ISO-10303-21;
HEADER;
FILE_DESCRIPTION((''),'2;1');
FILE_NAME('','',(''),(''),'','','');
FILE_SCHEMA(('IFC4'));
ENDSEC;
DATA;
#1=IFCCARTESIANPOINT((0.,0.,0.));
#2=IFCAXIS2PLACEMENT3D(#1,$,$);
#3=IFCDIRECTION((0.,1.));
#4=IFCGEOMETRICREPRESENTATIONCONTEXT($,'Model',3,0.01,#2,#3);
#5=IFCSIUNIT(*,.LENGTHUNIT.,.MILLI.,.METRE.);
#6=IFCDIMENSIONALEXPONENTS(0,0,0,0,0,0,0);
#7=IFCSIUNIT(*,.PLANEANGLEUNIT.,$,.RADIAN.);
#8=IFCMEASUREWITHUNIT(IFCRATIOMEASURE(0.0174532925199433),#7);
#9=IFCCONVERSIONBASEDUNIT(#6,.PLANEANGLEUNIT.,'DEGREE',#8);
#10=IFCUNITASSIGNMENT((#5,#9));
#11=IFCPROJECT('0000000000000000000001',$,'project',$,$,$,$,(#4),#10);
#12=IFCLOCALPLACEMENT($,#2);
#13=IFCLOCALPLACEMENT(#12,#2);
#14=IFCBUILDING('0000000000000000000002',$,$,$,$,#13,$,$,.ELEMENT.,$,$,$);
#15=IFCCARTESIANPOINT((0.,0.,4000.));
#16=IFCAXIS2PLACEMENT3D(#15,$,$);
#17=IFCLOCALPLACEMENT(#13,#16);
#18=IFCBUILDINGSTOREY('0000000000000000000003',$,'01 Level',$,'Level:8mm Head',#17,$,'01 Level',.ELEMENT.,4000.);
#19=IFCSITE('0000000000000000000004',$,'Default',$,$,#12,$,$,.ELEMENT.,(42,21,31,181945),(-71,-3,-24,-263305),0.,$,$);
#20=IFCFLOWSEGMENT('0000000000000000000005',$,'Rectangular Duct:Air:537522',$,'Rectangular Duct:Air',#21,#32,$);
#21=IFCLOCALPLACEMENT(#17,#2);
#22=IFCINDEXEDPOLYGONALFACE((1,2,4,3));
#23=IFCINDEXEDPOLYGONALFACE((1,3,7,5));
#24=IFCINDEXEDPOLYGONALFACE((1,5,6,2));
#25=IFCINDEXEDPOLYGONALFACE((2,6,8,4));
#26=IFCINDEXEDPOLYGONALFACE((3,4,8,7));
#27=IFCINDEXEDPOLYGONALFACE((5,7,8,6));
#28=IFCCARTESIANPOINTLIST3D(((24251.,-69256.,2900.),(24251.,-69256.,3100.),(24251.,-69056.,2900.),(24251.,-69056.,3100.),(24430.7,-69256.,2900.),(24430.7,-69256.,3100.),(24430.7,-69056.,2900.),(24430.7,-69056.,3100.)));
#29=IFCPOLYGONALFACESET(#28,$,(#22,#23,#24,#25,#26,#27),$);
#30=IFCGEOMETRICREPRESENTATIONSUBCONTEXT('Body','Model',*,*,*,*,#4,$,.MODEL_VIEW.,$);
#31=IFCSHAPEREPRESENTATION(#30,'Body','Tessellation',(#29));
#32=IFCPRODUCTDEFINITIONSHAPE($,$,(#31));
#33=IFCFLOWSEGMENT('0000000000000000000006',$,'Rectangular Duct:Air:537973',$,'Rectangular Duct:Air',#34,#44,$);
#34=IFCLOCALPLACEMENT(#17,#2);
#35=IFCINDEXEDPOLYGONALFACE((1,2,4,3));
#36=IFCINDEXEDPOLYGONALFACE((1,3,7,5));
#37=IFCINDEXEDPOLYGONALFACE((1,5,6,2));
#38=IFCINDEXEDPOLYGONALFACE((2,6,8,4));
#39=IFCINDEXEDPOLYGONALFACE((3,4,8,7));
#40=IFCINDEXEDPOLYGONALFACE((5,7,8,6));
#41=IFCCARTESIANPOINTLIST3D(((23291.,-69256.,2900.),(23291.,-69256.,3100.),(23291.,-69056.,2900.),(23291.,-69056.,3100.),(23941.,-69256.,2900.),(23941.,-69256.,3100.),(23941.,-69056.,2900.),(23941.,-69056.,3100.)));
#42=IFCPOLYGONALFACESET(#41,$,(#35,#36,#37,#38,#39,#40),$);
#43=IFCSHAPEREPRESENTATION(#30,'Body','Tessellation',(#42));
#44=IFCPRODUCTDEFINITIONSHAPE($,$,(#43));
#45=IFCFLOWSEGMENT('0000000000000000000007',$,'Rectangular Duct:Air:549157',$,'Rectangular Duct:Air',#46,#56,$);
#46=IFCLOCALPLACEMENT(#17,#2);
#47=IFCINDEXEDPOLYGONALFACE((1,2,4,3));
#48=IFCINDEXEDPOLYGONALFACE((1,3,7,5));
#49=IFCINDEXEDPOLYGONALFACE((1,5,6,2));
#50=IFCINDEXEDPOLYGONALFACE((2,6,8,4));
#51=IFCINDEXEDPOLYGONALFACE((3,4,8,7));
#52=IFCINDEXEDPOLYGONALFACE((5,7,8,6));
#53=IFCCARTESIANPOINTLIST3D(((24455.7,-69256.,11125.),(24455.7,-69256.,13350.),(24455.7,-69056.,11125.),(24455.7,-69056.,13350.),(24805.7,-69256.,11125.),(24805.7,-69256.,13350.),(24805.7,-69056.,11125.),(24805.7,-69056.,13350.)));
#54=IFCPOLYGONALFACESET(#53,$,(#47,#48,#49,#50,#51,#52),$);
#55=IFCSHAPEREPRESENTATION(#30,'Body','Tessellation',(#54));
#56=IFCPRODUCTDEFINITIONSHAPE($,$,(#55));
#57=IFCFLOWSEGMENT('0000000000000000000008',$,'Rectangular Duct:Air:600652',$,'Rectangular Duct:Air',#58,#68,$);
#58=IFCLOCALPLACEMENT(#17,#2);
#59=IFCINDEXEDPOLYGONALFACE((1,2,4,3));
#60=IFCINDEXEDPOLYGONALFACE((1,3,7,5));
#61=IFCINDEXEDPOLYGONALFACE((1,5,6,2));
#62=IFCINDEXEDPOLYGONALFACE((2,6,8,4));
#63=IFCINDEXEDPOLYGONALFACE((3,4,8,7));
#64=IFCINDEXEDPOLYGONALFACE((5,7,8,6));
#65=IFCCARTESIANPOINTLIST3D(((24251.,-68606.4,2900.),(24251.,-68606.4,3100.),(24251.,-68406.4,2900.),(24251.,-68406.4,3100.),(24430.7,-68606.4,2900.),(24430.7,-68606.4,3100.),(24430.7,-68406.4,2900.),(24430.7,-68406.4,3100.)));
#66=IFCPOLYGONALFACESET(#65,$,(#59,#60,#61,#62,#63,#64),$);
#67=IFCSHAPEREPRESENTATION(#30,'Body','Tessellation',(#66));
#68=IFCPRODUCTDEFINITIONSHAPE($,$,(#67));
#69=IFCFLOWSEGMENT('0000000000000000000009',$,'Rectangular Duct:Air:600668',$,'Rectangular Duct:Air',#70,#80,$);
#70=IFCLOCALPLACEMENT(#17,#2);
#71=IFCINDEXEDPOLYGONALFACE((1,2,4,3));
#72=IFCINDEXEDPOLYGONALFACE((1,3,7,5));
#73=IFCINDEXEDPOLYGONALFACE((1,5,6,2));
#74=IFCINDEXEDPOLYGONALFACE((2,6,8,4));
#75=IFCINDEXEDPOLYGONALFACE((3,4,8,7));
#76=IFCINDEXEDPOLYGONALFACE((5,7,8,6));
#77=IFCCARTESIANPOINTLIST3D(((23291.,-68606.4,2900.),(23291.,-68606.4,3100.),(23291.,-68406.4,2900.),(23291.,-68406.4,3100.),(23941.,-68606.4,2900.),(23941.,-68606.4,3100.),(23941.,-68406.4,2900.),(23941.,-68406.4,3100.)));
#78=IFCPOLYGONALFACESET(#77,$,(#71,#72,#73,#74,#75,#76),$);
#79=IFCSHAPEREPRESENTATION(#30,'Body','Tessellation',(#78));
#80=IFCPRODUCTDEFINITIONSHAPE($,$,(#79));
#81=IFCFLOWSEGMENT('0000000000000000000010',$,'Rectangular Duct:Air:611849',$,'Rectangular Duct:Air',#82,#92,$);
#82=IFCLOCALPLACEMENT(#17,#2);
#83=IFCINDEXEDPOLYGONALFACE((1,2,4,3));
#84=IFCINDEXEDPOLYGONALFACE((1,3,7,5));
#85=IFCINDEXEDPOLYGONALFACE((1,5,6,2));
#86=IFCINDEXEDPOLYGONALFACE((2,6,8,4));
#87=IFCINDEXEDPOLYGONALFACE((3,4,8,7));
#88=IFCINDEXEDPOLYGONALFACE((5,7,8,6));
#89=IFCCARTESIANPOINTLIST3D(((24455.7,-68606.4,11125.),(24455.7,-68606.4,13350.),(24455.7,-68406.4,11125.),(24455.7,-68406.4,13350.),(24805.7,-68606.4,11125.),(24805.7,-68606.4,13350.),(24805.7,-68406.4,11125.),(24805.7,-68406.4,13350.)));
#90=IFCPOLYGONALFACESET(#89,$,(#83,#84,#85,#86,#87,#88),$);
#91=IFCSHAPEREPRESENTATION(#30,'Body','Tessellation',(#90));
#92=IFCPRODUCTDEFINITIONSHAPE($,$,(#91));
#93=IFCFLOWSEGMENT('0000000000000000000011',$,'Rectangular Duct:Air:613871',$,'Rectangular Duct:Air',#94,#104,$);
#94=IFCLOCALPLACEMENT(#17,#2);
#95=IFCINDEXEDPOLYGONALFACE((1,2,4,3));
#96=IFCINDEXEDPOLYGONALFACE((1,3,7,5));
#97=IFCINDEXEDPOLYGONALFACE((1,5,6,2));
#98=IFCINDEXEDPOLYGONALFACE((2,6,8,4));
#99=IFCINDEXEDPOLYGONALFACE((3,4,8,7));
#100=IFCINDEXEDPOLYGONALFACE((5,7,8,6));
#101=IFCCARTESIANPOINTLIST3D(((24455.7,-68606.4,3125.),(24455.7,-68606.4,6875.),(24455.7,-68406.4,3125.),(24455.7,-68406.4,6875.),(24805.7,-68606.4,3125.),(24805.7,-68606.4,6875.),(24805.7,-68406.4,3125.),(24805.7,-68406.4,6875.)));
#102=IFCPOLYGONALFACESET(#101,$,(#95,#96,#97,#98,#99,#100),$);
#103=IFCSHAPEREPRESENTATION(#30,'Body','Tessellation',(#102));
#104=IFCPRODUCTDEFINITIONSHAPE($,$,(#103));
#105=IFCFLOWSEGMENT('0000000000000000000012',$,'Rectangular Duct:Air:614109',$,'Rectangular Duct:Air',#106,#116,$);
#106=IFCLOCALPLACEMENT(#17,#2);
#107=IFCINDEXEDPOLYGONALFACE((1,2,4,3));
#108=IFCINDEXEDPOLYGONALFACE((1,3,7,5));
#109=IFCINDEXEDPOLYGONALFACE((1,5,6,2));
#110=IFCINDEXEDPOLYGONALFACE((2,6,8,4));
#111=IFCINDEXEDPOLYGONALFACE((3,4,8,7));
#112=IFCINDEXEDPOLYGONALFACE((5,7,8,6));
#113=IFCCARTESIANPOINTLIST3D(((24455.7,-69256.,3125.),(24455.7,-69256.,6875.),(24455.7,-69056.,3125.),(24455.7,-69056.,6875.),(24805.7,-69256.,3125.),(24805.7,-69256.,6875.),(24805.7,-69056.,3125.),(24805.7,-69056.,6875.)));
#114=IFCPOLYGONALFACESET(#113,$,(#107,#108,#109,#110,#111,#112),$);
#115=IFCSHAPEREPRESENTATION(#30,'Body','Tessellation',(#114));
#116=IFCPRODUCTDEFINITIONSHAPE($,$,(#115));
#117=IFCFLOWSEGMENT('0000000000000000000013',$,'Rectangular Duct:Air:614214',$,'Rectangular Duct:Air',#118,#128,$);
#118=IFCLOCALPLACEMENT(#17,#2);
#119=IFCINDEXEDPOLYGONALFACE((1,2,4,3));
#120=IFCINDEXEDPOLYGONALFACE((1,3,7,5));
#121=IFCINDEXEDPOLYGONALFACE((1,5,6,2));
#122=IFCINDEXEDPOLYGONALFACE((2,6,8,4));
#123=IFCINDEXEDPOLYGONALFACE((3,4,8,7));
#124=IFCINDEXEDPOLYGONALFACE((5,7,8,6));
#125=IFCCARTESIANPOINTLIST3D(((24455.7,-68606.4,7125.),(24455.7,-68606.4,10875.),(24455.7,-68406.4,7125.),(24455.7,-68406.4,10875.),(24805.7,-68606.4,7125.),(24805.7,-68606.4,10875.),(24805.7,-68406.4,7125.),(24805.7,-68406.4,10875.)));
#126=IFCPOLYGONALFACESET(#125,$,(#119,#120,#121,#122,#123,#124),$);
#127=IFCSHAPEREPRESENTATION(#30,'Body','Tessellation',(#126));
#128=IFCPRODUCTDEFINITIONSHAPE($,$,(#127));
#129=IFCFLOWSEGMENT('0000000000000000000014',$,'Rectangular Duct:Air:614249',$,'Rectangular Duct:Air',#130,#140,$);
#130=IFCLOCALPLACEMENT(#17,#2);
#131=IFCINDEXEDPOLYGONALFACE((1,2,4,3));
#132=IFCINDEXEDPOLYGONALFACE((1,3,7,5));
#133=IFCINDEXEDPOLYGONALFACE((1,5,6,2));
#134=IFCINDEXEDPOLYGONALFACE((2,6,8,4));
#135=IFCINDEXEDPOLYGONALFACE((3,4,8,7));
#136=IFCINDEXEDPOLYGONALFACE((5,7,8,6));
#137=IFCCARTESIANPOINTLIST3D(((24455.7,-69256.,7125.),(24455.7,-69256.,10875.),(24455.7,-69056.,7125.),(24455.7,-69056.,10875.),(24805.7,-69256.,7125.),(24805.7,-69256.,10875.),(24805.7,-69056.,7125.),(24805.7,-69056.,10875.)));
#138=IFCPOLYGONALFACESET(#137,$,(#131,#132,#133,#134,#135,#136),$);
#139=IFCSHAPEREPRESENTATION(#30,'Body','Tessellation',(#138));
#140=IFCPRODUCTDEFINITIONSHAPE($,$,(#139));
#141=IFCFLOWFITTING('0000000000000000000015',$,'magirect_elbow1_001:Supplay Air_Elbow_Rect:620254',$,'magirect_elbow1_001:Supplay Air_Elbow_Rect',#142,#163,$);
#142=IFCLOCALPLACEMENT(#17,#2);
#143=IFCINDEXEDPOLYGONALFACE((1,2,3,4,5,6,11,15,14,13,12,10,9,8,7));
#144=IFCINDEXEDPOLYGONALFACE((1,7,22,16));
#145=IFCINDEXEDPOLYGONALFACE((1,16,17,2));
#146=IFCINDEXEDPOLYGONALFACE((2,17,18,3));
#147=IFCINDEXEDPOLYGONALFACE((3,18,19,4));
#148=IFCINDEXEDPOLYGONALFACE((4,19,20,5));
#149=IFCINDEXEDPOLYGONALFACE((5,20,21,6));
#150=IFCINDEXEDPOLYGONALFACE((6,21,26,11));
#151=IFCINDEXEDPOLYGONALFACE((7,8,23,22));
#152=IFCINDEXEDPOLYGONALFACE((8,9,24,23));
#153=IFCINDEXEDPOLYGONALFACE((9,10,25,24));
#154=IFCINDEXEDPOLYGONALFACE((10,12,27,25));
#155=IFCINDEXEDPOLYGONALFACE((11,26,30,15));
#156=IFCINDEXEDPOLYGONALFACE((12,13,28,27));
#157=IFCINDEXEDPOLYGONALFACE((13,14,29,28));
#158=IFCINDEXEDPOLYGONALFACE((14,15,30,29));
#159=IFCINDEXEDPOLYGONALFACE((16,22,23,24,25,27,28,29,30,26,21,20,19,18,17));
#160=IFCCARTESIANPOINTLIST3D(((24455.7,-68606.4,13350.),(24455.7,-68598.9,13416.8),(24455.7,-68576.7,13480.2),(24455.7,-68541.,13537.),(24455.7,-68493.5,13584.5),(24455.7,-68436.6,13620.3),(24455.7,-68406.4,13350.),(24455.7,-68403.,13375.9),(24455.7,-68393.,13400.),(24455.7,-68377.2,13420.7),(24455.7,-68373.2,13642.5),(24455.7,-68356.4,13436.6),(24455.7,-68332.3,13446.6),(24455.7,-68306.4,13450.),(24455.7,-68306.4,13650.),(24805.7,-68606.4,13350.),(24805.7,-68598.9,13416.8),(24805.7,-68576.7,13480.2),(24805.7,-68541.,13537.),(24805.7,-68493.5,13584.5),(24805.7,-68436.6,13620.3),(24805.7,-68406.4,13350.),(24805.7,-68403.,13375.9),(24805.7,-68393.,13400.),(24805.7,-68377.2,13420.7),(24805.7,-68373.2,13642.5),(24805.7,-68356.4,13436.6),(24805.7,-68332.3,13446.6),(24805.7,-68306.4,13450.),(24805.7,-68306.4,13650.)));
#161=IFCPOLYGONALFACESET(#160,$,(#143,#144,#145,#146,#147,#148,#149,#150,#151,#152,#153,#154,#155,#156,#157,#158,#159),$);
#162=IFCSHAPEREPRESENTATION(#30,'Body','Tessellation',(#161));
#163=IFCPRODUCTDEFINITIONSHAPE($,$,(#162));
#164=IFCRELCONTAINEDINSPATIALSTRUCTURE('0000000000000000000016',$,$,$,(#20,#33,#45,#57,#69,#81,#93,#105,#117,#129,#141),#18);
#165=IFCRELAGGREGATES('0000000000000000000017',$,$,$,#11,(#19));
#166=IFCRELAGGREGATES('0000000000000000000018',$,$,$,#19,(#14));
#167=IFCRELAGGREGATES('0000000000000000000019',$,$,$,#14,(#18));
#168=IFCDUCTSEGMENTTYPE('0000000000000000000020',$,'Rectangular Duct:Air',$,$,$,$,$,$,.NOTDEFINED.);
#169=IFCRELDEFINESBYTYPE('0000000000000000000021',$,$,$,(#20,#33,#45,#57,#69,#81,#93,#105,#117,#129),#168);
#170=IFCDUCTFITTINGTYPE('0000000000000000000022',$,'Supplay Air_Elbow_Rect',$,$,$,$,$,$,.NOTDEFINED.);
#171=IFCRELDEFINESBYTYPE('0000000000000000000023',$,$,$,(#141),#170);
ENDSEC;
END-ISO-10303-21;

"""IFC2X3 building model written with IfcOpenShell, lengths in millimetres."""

from ifc_helpers import new_model, entity, si_unit, converted_unit, direction, frame, frame_2d, origin, place, context, subcontext, project, spatial, polyline, circle_curve, parameter, trimmed, segment, composite_curve, rectangle, outline, extrude, source, transform, mapped, type_object, type_shapes, element, save


model = new_model("IFC2X3")

# Units and contexts
model_context = context("Model", 3, precision=0.01, world=origin(), true_north=direction((0.0, 1.0)))
body_context = subcontext(model_context, "Body", "Model", "MODEL_VIEW")
ifc_project = project(units=[si_unit("LENGTHUNIT", "METRE", prefix="MILLI"), converted_unit("PLANEANGLEUNIT", "DEGREE", entity("IfcRatioMeasure", 0.0174532925199433), si_unit("PLANEANGLEUNIT", "RADIAN"), dimensions=[0, 0, 0, 0, 0, 0, 0])], contexts=[model_context])

# Site, building, storey
site_placement = place(None, origin())
site = spatial("IfcSite", under=ifc_project, at=site_placement, Name="Default", CompositionType="ELEMENT", RefLatitude=(42, 21, 31, 181945), RefLongitude=(-71, -3, -24, -263305), RefElevation=0.0)
building_placement = place(site_placement, origin())
building = spatial("IfcBuilding", under=site, at=building_placement, CompositionType="ELEMENT")
storey_placement = place(building_placement, frame((0.0, 0.0, 4000.0)))
storey = spatial("IfcBuildingStorey", under=building, at=storey_placement, Name="01 Level", ObjectType="Level:8mm Head", LongName="01 Level", CompositionType="ELEMENT", Elevation=4000.0)

# Flow segments
duct_segment_type_1 = type_object("IfcDuctSegmentType", Name="Rectangular Duct:Air", PredefinedType="NOTDEFINED")
flow_segment_1_placement = place(storey_placement, frame((24251.0, -69256.0, 2900.0)))
element("IfcFlowSegment", 1, at=flow_segment_1_placement, inside=storey, type_object=duct_segment_type_1, Name="Rectangular Duct:Air:537522", ObjectType="Rectangular Duct:Air", context=body_context, shape_type="SweptSolid", body=[
    extrude(rectangle(XDim=179.7, YDim=200.0, at=frame_2d((0.0, 0.0), x_axis=(1.0, 0.0))), frame((89.8, 100.0, 0.0)), (0.0, 0.0, 1.0), 200.0),
])
flow_segment_2_placement = place(storey_placement, frame((23291.0, -69256.0, 2900.0)))
element("IfcFlowSegment", 2, at=flow_segment_2_placement, inside=storey, type_object=duct_segment_type_1, Name="Rectangular Duct:Air:537973", ObjectType="Rectangular Duct:Air", context=body_context, shape_type="SweptSolid", body=[
    extrude(rectangle(XDim=650.0, YDim=200.0, at=frame_2d((0.0, 0.0), x_axis=(1.0, 0.0))), frame((325.0, 100.0, 0.0), z_axis=(0.0, 0.0, 1.0), x_axis=(-1.0, 0.0, 0.0)), (0.0, 0.0, 1.0), 200.0),
])
flow_segment_3_placement = place(storey_placement, frame((24455.7, -69256.0, 11125.0)))
element("IfcFlowSegment", 3, at=flow_segment_3_placement, inside=storey, type_object=duct_segment_type_1, Name="Rectangular Duct:Air:549157", ObjectType="Rectangular Duct:Air", context=body_context, shape_type="SweptSolid", body=[
    extrude(rectangle(XDim=350.0, YDim=200.0, at=frame_2d((0.0, 0.0), x_axis=(1.0, 0.0))), frame((175.0, 100.0, 0.0)), (0.0, 0.0, 1.0), 2225.0),
])
flow_segment_4_placement = place(storey_placement, frame((24251.0, -68606.4, 2900.0)))
element("IfcFlowSegment", 4, at=flow_segment_4_placement, inside=storey, type_object=duct_segment_type_1, Name="Rectangular Duct:Air:600652", ObjectType="Rectangular Duct:Air", context=body_context, shape_type="SweptSolid", body=[
    extrude(rectangle(XDim=179.7, YDim=200.0, at=frame_2d((0.0, 0.0), x_axis=(1.0, 0.0))), frame((89.8, 100.0, 0.0)), (0.0, 0.0, 1.0), 200.0),
])
flow_segment_5_placement = place(storey_placement, frame((23291.0, -68606.4, 2900.0)))
element("IfcFlowSegment", 5, at=flow_segment_5_placement, inside=storey, type_object=duct_segment_type_1, Name="Rectangular Duct:Air:600668", ObjectType="Rectangular Duct:Air", context=body_context, shape_type="SweptSolid", body=[
    extrude(rectangle(XDim=650.0, YDim=200.0, at=frame_2d((0.0, 0.0), x_axis=(1.0, 0.0))), frame((325.0, 100.0, 0.0), z_axis=(0.0, 0.0, 1.0), x_axis=(-1.0, 0.0, 0.0)), (0.0, 0.0, 1.0), 200.0),
])
flow_segment_6_placement = place(storey_placement, frame((24455.7, -68606.4, 11125.0)))
element("IfcFlowSegment", 6, at=flow_segment_6_placement, inside=storey, type_object=duct_segment_type_1, Name="Rectangular Duct:Air:611849", ObjectType="Rectangular Duct:Air", context=body_context, shape_type="SweptSolid", body=[
    extrude(rectangle(XDim=200.0, YDim=350.0, at=frame_2d((0.0, 0.0), x_axis=(1.0, 0.0))), frame((175.0, 100.0, 0.0), z_axis=(0.0, 0.0, 1.0), x_axis=(0.0, -1.0, 0.0)), (0.0, 0.0, 1.0), 2225.0),
])
flow_segment_7_placement = place(storey_placement, frame((24455.7, -68606.4, 3125.0)))
element("IfcFlowSegment", 7, at=flow_segment_7_placement, inside=storey, type_object=duct_segment_type_1, Name="Rectangular Duct:Air:613871", ObjectType="Rectangular Duct:Air", context=body_context, shape_type="SweptSolid", body=[
    extrude(rectangle(XDim=350.0, YDim=200.0, at=frame_2d((0.0, 0.0), x_axis=(1.0, 0.0))), frame((175.0, 100.0, 0.0), z_axis=(0.0, 0.0, 1.0), x_axis=(-1.0, 0.0, 0.0)), (0.0, 0.0, 1.0), 3750.0),
])
flow_segment_8_placement = place(storey_placement, frame((24455.7, -69256.0, 3125.0)))
element("IfcFlowSegment", 8, at=flow_segment_8_placement, inside=storey, type_object=duct_segment_type_1, Name="Rectangular Duct:Air:614109", ObjectType="Rectangular Duct:Air", context=body_context, shape_type="SweptSolid", body=[
    extrude(rectangle(XDim=200.0, YDim=350.0, at=frame_2d((0.0, 0.0), x_axis=(1.0, 0.0))), frame((175.0, 100.0, 0.0), z_axis=(0.0, 0.0, 1.0), x_axis=(0.0, 1.0, 0.0)), (0.0, 0.0, 1.0), 3750.0),
])
flow_segment_9_placement = place(storey_placement, frame((24455.7, -68606.4, 7125.0)))
element("IfcFlowSegment", 9, at=flow_segment_9_placement, inside=storey, type_object=duct_segment_type_1, Name="Rectangular Duct:Air:614214", ObjectType="Rectangular Duct:Air", context=body_context, shape_type="SweptSolid", body=[
    extrude(rectangle(XDim=200.0, YDim=350.0, at=frame_2d((0.0, 0.0), x_axis=(1.0, 0.0))), frame((175.0, 100.0, 0.0), z_axis=(0.0, 0.0, 1.0), x_axis=(0.0, -1.0, 0.0)), (0.0, 0.0, 1.0), 3750.0),
])
flow_segment_10_placement = place(storey_placement, frame((24455.7, -69256.0, 7125.0)))
element("IfcFlowSegment", 10, at=flow_segment_10_placement, inside=storey, type_object=duct_segment_type_1, Name="Rectangular Duct:Air:614249", ObjectType="Rectangular Duct:Air", context=body_context, shape_type="SweptSolid", body=[
    extrude(rectangle(XDim=200.0, YDim=350.0, at=frame_2d((0.0, 0.0), x_axis=(1.0, 0.0))), frame((175.0, 100.0, 0.0), z_axis=(0.0, 0.0, 1.0), x_axis=(0.0, 1.0, 0.0)), (0.0, 0.0, 1.0), 3750.0),
])

# Flow fitting
duct_fitting_type_1 = type_object("IfcDuctFittingType", Name="Supplay Air_Elbow_Rect", PredefinedType="NOTDEFINED")
shared_shape_1 = source(origin(), body_context, "Body", "SweptSolid", [
    extrude(outline(composite_curve([segment(polyline([(-200.0, -100.0), (0.0, -100.0)]), True, "CONTINUOUS"), segment(trimmed(circle_curve(frame_2d((100.0, -100.0), x_axis=(0.0, 1.0)), 100.0), [parameter(0.0)], [parameter(90.0)], True, "PARAMETER"), False, "CONTINUOUS"), segment(polyline([(100.0, 0.0), (100.0, 200.0)]), True, "CONTINUOUS"), segment(trimmed(circle_curve(frame_2d((100.0, -100.0), x_axis=(0.0, 1.0)), 300.0), [parameter(0.0)], [parameter(90.0)], True, "PARAMETER"), True, "CONTINUOUS")], self_intersect=False)), frame((-100.0, 100.0, -175.0), z_axis=(0.0, 0.0, 1.0), x_axis=(-1.0, 0.0, 0.0)), (0.0, 0.0, 1.0), 350.0),
])
type_shapes(duct_fitting_type_1, [shared_shape_1])
flow_fitting_1_placement = place(storey_placement, frame((24630.7, -68506.4, 13550.0), z_axis=(-1.0, 0.0, 0.0), x_axis=(0.0, 0.0, 1.0)))
element("IfcFlowFitting", 11, at=flow_fitting_1_placement, inside=storey, type_object=duct_fitting_type_1, Name="magirect_elbow1_001:Supplay Air_Elbow_Rect:620254", ObjectType="magirect_elbow1_001:Supplay Air_Elbow_Rect", context=body_context, shape_type="MappedRepresentation", body=[
    mapped(shared_shape_1, transform((0.0, 0.0, 0.0), scale=1.0)),
])

save(model, "model.ifc")
